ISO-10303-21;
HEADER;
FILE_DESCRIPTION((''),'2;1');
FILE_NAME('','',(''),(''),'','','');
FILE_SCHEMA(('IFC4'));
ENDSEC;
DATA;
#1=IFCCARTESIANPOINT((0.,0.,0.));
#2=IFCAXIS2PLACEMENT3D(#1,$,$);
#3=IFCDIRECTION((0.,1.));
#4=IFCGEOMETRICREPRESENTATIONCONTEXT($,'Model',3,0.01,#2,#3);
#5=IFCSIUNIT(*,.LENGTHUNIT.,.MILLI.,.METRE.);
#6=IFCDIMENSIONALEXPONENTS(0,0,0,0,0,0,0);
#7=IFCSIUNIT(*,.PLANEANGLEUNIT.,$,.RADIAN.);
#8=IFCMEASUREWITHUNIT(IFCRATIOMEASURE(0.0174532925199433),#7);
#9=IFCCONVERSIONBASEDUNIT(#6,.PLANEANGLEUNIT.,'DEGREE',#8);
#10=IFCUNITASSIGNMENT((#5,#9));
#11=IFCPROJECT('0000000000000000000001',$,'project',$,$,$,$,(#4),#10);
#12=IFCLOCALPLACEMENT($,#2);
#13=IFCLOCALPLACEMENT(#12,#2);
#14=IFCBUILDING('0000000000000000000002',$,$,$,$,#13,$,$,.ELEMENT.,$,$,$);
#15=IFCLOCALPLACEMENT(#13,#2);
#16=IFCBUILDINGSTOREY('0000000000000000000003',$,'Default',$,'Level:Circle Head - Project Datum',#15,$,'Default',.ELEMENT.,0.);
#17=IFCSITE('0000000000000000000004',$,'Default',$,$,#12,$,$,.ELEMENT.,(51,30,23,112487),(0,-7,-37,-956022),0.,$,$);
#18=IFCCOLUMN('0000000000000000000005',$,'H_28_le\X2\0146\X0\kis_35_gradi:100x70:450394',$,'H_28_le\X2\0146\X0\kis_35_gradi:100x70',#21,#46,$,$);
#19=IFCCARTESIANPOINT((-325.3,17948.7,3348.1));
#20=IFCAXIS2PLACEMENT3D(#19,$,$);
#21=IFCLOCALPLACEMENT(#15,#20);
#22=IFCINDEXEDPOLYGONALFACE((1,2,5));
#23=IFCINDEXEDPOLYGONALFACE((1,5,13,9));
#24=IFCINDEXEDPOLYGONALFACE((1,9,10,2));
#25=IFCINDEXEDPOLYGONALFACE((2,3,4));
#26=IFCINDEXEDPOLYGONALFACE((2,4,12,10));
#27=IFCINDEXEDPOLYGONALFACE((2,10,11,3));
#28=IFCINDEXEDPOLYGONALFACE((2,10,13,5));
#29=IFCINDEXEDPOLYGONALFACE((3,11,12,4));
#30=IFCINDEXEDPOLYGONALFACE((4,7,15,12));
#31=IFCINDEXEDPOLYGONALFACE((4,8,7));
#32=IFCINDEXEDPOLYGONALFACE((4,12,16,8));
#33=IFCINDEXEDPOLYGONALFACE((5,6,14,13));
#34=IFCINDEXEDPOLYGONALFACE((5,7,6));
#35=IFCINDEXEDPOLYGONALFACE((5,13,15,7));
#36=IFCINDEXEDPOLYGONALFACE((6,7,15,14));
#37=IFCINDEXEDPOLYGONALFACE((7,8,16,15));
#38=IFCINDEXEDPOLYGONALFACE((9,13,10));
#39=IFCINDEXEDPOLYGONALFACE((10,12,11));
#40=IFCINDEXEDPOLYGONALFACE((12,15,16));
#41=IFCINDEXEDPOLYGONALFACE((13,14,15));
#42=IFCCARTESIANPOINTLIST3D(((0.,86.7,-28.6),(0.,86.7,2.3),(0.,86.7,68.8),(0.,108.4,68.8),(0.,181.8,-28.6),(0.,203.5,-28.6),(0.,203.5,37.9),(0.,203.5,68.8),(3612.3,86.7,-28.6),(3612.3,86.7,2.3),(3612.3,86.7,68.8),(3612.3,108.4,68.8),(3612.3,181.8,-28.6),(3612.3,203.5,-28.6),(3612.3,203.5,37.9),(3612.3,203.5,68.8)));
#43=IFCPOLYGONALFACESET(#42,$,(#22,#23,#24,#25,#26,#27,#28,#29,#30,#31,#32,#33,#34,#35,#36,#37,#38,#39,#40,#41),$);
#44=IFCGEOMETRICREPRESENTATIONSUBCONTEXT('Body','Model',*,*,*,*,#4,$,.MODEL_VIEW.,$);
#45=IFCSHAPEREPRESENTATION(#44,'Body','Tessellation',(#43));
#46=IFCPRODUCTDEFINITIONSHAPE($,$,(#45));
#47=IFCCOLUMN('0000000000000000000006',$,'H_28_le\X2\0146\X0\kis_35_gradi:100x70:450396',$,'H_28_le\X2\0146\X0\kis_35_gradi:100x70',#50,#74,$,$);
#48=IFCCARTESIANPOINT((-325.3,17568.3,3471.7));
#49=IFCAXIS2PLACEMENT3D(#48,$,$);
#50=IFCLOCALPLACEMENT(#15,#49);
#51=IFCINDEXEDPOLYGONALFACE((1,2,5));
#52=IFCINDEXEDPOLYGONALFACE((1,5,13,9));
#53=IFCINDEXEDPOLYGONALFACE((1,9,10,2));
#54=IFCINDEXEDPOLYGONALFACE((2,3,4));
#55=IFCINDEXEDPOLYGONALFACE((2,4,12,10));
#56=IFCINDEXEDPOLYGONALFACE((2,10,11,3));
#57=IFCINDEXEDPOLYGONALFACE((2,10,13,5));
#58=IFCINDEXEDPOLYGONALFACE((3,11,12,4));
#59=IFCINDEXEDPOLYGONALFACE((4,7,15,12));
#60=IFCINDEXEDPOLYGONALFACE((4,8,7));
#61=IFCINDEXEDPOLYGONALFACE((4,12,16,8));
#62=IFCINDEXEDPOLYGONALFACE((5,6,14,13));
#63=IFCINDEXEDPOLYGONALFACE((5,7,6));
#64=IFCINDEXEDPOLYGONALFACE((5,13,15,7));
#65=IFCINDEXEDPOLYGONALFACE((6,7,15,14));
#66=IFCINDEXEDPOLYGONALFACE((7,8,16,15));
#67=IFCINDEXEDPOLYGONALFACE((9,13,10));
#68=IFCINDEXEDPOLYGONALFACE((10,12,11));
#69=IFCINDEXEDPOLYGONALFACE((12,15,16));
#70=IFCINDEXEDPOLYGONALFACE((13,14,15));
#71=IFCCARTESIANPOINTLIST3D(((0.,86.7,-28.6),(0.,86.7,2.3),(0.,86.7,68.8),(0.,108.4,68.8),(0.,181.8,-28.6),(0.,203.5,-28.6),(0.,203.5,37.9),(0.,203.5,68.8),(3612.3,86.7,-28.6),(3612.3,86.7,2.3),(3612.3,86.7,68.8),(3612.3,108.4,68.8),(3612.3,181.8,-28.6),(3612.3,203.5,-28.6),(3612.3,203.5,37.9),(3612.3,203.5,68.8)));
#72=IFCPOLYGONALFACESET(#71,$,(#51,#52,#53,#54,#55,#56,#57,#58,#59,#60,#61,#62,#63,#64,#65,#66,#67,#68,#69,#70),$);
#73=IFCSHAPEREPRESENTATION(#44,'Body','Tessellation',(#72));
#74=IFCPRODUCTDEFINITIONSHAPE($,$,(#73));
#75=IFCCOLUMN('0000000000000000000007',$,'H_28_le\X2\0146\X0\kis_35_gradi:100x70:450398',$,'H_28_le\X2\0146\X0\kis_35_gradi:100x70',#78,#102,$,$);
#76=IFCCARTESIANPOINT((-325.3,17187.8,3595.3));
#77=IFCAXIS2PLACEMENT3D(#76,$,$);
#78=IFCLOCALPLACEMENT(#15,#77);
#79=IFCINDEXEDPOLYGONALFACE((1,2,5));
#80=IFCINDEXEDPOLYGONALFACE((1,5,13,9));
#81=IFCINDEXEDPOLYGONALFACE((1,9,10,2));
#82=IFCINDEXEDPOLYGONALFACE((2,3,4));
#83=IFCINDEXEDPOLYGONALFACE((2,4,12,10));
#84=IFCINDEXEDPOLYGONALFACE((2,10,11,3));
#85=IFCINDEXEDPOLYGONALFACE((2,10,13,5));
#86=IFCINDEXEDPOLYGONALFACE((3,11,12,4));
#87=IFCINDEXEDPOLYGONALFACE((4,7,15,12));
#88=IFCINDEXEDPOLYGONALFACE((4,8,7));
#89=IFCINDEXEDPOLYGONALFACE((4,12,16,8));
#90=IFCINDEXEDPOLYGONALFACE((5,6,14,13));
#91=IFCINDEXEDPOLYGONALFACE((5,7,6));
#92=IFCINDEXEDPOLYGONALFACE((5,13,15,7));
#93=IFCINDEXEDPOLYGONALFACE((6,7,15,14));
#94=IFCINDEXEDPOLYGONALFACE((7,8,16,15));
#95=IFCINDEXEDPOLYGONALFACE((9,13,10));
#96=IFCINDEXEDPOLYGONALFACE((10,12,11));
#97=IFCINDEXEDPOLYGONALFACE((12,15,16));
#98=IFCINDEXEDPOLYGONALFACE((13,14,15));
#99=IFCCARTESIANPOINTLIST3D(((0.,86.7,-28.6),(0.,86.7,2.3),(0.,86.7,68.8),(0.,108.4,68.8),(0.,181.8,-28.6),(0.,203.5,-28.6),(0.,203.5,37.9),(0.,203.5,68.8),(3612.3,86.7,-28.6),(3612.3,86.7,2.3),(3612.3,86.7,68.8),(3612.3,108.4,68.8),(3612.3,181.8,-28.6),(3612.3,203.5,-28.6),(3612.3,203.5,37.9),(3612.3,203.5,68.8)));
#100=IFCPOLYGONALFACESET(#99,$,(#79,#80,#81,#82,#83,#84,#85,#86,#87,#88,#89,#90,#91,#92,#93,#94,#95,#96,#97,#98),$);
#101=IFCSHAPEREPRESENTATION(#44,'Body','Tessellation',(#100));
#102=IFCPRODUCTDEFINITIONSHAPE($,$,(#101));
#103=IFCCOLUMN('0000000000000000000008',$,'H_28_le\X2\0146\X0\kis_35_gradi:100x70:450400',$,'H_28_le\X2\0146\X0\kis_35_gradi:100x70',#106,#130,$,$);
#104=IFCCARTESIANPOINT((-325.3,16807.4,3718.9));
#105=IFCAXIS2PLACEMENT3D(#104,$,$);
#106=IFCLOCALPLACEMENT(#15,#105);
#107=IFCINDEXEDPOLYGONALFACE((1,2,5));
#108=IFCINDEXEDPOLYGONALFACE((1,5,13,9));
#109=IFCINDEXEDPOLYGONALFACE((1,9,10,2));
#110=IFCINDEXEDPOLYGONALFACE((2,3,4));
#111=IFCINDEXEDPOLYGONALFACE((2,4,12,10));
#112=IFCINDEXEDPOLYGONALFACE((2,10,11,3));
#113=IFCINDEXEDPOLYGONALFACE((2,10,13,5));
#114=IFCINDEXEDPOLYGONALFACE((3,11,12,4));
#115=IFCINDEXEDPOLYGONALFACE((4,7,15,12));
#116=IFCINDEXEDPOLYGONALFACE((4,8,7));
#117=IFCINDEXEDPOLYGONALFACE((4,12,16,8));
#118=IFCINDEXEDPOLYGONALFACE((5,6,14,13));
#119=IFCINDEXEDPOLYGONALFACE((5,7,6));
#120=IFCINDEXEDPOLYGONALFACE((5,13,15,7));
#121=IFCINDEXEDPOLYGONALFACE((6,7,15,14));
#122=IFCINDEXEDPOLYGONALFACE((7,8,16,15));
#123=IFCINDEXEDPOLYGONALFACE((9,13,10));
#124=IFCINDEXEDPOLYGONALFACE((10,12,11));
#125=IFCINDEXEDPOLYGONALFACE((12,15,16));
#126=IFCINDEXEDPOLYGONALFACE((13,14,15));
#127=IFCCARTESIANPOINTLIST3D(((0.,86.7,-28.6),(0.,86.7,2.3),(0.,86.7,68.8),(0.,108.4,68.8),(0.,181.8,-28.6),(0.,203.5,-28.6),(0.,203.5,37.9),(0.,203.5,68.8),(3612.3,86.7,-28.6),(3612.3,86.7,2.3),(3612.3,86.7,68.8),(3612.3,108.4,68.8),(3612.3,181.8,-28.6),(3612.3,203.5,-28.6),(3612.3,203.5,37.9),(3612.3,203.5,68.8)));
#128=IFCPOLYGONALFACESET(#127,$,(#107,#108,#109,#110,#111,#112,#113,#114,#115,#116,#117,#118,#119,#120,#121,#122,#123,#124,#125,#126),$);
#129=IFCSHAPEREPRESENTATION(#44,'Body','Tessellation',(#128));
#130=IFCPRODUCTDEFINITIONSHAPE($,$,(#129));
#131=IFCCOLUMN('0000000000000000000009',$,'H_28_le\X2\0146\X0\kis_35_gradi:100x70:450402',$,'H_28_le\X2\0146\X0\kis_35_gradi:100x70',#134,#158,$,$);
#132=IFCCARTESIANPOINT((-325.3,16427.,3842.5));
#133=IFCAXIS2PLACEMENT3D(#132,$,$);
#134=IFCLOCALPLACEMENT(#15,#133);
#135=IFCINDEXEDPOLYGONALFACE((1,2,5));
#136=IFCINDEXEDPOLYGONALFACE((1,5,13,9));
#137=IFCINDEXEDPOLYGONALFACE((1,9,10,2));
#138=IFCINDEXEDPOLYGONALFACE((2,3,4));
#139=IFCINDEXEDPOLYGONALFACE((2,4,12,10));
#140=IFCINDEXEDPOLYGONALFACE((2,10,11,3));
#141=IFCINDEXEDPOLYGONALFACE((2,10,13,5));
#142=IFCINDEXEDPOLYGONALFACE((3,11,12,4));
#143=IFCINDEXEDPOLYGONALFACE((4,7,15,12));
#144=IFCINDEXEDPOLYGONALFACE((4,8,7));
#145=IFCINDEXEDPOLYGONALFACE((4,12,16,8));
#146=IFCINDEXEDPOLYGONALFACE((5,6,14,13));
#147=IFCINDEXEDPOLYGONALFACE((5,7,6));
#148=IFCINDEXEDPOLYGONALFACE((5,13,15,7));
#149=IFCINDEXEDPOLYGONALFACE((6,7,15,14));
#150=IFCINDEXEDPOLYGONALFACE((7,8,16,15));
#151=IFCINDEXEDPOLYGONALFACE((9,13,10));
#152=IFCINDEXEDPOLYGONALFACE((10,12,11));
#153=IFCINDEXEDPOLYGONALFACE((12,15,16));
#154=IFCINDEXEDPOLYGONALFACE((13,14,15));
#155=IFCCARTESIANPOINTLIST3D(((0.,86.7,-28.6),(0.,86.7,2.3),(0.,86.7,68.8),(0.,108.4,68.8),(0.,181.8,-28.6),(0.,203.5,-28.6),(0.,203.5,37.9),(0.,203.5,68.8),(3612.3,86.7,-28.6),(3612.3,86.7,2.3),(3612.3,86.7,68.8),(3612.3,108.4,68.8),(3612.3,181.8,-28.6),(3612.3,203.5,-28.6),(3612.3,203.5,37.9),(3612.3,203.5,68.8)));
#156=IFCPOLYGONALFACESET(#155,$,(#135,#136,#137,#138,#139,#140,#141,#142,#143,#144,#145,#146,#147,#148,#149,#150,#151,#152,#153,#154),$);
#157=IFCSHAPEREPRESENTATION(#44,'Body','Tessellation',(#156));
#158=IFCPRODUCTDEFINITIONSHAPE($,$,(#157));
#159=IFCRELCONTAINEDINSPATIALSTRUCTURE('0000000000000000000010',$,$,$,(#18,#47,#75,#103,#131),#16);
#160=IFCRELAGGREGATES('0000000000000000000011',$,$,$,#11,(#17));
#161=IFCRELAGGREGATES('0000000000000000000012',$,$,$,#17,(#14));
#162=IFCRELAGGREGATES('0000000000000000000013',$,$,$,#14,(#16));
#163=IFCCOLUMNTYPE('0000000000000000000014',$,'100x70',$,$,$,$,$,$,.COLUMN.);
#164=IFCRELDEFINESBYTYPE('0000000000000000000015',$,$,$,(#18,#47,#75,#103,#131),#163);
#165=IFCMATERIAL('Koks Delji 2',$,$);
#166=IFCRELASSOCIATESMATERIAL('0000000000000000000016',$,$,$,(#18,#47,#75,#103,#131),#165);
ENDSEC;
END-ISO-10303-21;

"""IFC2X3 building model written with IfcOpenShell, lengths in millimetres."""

from ifc_helpers import new_model, entity, si_unit, converted_unit, direction, frame, frame_2d, origin, origin_2d_with_axis, place, context, subcontext, project, spatial, rectangle, extrude, boolean, source, transform, mapped, material, type_object, type_shapes, element, save


model = new_model("IFC2X3")

# Units and contexts
model_context = context("Model", 3, precision=0.01, world=origin(), true_north=direction((0.0, 1.0)))
body_context = subcontext(model_context, "Body", "Model", "MODEL_VIEW")
ifc_project = project(units=[si_unit("LENGTHUNIT", "METRE", prefix="MILLI"), converted_unit("PLANEANGLEUNIT", "DEGREE", entity("IfcRatioMeasure", 0.0174532925199433), si_unit("PLANEANGLEUNIT", "RADIAN"), dimensions=[0, 0, 0, 0, 0, 0, 0])], contexts=[model_context])

# Site, building, storey
site_placement = place(None, origin())
site = spatial("IfcSite", under=ifc_project, at=site_placement, Name="Default", CompositionType="ELEMENT", RefLatitude=(51, 30, 23, 112487), RefLongitude=(0, -7, -37, -956022), RefElevation=0.0)
building_placement = place(site_placement, origin())
building = spatial("IfcBuilding", under=site, at=building_placement, CompositionType="ELEMENT")
storey_placement = place(building_placement, origin())
storey = spatial("IfcBuildingStorey", under=building, at=storey_placement, Name="Default", ObjectType="Level:Circle Head - Project Datum", LongName="Default", CompositionType="ELEMENT", Elevation=0.0)

# Columns
ifc_material_1 = material(Name="Koks Delji 2")
column_type = type_object("IfcColumnType", Name="100x70", PredefinedType="COLUMN")
shared_shape_1 = source(origin(), body_context, "Body", "CSG", [
    boolean("DIFFERENCE", extrude(rectangle(XDim=3612.3, YDim=116.7, at=origin_2d_with_axis()), frame((1806.1, 145.1, -28.6)), (0.0, 0.0, 1.0), 97.5), extrude(rectangle(XDim=70.0, YDim=100.0, at=frame_2d((0.0, 0.0), x_axis=(0.0, 1.0))), frame((3612.3, 145.1, 20.1), z_axis=(1.0, 0.0, 0.0), x_axis=(0.0, 0.951057, -0.309017)), (0.0, 0.0, -1.0), 3612.3)),
])
type_shapes(column_type, [shared_shape_1])
for number, where, name in (
    (1, (-325.3, 17948.7, 3348.1), "H_28_leņkis_35_gradi:100x70:450394"),
    (2, (-325.3, 17568.3, 3471.7), "H_28_leņkis_35_gradi:100x70:450396"),
    (3, (-325.3, 17187.8, 3595.3), "H_28_leņkis_35_gradi:100x70:450398"),
    (4, (-325.3, 16807.4, 3718.9), "H_28_leņkis_35_gradi:100x70:450400"),
    (5, (-325.3, 16427.0, 3842.5), "H_28_leņkis_35_gradi:100x70:450402"),
):
    element("IfcColumn", number, at=place(storey_placement, frame(where)), inside=storey, type_object=column_type, material=ifc_material_1, Name=name, ObjectType="H_28_leņkis_35_gradi:100x70", context=body_context, shape_type="MappedRepresentation", body=[
        mapped(shared_shape_1, transform((0.0, 0.0, 0.0), scale=1.0)),
    ])

save(model, "model.ifc")
